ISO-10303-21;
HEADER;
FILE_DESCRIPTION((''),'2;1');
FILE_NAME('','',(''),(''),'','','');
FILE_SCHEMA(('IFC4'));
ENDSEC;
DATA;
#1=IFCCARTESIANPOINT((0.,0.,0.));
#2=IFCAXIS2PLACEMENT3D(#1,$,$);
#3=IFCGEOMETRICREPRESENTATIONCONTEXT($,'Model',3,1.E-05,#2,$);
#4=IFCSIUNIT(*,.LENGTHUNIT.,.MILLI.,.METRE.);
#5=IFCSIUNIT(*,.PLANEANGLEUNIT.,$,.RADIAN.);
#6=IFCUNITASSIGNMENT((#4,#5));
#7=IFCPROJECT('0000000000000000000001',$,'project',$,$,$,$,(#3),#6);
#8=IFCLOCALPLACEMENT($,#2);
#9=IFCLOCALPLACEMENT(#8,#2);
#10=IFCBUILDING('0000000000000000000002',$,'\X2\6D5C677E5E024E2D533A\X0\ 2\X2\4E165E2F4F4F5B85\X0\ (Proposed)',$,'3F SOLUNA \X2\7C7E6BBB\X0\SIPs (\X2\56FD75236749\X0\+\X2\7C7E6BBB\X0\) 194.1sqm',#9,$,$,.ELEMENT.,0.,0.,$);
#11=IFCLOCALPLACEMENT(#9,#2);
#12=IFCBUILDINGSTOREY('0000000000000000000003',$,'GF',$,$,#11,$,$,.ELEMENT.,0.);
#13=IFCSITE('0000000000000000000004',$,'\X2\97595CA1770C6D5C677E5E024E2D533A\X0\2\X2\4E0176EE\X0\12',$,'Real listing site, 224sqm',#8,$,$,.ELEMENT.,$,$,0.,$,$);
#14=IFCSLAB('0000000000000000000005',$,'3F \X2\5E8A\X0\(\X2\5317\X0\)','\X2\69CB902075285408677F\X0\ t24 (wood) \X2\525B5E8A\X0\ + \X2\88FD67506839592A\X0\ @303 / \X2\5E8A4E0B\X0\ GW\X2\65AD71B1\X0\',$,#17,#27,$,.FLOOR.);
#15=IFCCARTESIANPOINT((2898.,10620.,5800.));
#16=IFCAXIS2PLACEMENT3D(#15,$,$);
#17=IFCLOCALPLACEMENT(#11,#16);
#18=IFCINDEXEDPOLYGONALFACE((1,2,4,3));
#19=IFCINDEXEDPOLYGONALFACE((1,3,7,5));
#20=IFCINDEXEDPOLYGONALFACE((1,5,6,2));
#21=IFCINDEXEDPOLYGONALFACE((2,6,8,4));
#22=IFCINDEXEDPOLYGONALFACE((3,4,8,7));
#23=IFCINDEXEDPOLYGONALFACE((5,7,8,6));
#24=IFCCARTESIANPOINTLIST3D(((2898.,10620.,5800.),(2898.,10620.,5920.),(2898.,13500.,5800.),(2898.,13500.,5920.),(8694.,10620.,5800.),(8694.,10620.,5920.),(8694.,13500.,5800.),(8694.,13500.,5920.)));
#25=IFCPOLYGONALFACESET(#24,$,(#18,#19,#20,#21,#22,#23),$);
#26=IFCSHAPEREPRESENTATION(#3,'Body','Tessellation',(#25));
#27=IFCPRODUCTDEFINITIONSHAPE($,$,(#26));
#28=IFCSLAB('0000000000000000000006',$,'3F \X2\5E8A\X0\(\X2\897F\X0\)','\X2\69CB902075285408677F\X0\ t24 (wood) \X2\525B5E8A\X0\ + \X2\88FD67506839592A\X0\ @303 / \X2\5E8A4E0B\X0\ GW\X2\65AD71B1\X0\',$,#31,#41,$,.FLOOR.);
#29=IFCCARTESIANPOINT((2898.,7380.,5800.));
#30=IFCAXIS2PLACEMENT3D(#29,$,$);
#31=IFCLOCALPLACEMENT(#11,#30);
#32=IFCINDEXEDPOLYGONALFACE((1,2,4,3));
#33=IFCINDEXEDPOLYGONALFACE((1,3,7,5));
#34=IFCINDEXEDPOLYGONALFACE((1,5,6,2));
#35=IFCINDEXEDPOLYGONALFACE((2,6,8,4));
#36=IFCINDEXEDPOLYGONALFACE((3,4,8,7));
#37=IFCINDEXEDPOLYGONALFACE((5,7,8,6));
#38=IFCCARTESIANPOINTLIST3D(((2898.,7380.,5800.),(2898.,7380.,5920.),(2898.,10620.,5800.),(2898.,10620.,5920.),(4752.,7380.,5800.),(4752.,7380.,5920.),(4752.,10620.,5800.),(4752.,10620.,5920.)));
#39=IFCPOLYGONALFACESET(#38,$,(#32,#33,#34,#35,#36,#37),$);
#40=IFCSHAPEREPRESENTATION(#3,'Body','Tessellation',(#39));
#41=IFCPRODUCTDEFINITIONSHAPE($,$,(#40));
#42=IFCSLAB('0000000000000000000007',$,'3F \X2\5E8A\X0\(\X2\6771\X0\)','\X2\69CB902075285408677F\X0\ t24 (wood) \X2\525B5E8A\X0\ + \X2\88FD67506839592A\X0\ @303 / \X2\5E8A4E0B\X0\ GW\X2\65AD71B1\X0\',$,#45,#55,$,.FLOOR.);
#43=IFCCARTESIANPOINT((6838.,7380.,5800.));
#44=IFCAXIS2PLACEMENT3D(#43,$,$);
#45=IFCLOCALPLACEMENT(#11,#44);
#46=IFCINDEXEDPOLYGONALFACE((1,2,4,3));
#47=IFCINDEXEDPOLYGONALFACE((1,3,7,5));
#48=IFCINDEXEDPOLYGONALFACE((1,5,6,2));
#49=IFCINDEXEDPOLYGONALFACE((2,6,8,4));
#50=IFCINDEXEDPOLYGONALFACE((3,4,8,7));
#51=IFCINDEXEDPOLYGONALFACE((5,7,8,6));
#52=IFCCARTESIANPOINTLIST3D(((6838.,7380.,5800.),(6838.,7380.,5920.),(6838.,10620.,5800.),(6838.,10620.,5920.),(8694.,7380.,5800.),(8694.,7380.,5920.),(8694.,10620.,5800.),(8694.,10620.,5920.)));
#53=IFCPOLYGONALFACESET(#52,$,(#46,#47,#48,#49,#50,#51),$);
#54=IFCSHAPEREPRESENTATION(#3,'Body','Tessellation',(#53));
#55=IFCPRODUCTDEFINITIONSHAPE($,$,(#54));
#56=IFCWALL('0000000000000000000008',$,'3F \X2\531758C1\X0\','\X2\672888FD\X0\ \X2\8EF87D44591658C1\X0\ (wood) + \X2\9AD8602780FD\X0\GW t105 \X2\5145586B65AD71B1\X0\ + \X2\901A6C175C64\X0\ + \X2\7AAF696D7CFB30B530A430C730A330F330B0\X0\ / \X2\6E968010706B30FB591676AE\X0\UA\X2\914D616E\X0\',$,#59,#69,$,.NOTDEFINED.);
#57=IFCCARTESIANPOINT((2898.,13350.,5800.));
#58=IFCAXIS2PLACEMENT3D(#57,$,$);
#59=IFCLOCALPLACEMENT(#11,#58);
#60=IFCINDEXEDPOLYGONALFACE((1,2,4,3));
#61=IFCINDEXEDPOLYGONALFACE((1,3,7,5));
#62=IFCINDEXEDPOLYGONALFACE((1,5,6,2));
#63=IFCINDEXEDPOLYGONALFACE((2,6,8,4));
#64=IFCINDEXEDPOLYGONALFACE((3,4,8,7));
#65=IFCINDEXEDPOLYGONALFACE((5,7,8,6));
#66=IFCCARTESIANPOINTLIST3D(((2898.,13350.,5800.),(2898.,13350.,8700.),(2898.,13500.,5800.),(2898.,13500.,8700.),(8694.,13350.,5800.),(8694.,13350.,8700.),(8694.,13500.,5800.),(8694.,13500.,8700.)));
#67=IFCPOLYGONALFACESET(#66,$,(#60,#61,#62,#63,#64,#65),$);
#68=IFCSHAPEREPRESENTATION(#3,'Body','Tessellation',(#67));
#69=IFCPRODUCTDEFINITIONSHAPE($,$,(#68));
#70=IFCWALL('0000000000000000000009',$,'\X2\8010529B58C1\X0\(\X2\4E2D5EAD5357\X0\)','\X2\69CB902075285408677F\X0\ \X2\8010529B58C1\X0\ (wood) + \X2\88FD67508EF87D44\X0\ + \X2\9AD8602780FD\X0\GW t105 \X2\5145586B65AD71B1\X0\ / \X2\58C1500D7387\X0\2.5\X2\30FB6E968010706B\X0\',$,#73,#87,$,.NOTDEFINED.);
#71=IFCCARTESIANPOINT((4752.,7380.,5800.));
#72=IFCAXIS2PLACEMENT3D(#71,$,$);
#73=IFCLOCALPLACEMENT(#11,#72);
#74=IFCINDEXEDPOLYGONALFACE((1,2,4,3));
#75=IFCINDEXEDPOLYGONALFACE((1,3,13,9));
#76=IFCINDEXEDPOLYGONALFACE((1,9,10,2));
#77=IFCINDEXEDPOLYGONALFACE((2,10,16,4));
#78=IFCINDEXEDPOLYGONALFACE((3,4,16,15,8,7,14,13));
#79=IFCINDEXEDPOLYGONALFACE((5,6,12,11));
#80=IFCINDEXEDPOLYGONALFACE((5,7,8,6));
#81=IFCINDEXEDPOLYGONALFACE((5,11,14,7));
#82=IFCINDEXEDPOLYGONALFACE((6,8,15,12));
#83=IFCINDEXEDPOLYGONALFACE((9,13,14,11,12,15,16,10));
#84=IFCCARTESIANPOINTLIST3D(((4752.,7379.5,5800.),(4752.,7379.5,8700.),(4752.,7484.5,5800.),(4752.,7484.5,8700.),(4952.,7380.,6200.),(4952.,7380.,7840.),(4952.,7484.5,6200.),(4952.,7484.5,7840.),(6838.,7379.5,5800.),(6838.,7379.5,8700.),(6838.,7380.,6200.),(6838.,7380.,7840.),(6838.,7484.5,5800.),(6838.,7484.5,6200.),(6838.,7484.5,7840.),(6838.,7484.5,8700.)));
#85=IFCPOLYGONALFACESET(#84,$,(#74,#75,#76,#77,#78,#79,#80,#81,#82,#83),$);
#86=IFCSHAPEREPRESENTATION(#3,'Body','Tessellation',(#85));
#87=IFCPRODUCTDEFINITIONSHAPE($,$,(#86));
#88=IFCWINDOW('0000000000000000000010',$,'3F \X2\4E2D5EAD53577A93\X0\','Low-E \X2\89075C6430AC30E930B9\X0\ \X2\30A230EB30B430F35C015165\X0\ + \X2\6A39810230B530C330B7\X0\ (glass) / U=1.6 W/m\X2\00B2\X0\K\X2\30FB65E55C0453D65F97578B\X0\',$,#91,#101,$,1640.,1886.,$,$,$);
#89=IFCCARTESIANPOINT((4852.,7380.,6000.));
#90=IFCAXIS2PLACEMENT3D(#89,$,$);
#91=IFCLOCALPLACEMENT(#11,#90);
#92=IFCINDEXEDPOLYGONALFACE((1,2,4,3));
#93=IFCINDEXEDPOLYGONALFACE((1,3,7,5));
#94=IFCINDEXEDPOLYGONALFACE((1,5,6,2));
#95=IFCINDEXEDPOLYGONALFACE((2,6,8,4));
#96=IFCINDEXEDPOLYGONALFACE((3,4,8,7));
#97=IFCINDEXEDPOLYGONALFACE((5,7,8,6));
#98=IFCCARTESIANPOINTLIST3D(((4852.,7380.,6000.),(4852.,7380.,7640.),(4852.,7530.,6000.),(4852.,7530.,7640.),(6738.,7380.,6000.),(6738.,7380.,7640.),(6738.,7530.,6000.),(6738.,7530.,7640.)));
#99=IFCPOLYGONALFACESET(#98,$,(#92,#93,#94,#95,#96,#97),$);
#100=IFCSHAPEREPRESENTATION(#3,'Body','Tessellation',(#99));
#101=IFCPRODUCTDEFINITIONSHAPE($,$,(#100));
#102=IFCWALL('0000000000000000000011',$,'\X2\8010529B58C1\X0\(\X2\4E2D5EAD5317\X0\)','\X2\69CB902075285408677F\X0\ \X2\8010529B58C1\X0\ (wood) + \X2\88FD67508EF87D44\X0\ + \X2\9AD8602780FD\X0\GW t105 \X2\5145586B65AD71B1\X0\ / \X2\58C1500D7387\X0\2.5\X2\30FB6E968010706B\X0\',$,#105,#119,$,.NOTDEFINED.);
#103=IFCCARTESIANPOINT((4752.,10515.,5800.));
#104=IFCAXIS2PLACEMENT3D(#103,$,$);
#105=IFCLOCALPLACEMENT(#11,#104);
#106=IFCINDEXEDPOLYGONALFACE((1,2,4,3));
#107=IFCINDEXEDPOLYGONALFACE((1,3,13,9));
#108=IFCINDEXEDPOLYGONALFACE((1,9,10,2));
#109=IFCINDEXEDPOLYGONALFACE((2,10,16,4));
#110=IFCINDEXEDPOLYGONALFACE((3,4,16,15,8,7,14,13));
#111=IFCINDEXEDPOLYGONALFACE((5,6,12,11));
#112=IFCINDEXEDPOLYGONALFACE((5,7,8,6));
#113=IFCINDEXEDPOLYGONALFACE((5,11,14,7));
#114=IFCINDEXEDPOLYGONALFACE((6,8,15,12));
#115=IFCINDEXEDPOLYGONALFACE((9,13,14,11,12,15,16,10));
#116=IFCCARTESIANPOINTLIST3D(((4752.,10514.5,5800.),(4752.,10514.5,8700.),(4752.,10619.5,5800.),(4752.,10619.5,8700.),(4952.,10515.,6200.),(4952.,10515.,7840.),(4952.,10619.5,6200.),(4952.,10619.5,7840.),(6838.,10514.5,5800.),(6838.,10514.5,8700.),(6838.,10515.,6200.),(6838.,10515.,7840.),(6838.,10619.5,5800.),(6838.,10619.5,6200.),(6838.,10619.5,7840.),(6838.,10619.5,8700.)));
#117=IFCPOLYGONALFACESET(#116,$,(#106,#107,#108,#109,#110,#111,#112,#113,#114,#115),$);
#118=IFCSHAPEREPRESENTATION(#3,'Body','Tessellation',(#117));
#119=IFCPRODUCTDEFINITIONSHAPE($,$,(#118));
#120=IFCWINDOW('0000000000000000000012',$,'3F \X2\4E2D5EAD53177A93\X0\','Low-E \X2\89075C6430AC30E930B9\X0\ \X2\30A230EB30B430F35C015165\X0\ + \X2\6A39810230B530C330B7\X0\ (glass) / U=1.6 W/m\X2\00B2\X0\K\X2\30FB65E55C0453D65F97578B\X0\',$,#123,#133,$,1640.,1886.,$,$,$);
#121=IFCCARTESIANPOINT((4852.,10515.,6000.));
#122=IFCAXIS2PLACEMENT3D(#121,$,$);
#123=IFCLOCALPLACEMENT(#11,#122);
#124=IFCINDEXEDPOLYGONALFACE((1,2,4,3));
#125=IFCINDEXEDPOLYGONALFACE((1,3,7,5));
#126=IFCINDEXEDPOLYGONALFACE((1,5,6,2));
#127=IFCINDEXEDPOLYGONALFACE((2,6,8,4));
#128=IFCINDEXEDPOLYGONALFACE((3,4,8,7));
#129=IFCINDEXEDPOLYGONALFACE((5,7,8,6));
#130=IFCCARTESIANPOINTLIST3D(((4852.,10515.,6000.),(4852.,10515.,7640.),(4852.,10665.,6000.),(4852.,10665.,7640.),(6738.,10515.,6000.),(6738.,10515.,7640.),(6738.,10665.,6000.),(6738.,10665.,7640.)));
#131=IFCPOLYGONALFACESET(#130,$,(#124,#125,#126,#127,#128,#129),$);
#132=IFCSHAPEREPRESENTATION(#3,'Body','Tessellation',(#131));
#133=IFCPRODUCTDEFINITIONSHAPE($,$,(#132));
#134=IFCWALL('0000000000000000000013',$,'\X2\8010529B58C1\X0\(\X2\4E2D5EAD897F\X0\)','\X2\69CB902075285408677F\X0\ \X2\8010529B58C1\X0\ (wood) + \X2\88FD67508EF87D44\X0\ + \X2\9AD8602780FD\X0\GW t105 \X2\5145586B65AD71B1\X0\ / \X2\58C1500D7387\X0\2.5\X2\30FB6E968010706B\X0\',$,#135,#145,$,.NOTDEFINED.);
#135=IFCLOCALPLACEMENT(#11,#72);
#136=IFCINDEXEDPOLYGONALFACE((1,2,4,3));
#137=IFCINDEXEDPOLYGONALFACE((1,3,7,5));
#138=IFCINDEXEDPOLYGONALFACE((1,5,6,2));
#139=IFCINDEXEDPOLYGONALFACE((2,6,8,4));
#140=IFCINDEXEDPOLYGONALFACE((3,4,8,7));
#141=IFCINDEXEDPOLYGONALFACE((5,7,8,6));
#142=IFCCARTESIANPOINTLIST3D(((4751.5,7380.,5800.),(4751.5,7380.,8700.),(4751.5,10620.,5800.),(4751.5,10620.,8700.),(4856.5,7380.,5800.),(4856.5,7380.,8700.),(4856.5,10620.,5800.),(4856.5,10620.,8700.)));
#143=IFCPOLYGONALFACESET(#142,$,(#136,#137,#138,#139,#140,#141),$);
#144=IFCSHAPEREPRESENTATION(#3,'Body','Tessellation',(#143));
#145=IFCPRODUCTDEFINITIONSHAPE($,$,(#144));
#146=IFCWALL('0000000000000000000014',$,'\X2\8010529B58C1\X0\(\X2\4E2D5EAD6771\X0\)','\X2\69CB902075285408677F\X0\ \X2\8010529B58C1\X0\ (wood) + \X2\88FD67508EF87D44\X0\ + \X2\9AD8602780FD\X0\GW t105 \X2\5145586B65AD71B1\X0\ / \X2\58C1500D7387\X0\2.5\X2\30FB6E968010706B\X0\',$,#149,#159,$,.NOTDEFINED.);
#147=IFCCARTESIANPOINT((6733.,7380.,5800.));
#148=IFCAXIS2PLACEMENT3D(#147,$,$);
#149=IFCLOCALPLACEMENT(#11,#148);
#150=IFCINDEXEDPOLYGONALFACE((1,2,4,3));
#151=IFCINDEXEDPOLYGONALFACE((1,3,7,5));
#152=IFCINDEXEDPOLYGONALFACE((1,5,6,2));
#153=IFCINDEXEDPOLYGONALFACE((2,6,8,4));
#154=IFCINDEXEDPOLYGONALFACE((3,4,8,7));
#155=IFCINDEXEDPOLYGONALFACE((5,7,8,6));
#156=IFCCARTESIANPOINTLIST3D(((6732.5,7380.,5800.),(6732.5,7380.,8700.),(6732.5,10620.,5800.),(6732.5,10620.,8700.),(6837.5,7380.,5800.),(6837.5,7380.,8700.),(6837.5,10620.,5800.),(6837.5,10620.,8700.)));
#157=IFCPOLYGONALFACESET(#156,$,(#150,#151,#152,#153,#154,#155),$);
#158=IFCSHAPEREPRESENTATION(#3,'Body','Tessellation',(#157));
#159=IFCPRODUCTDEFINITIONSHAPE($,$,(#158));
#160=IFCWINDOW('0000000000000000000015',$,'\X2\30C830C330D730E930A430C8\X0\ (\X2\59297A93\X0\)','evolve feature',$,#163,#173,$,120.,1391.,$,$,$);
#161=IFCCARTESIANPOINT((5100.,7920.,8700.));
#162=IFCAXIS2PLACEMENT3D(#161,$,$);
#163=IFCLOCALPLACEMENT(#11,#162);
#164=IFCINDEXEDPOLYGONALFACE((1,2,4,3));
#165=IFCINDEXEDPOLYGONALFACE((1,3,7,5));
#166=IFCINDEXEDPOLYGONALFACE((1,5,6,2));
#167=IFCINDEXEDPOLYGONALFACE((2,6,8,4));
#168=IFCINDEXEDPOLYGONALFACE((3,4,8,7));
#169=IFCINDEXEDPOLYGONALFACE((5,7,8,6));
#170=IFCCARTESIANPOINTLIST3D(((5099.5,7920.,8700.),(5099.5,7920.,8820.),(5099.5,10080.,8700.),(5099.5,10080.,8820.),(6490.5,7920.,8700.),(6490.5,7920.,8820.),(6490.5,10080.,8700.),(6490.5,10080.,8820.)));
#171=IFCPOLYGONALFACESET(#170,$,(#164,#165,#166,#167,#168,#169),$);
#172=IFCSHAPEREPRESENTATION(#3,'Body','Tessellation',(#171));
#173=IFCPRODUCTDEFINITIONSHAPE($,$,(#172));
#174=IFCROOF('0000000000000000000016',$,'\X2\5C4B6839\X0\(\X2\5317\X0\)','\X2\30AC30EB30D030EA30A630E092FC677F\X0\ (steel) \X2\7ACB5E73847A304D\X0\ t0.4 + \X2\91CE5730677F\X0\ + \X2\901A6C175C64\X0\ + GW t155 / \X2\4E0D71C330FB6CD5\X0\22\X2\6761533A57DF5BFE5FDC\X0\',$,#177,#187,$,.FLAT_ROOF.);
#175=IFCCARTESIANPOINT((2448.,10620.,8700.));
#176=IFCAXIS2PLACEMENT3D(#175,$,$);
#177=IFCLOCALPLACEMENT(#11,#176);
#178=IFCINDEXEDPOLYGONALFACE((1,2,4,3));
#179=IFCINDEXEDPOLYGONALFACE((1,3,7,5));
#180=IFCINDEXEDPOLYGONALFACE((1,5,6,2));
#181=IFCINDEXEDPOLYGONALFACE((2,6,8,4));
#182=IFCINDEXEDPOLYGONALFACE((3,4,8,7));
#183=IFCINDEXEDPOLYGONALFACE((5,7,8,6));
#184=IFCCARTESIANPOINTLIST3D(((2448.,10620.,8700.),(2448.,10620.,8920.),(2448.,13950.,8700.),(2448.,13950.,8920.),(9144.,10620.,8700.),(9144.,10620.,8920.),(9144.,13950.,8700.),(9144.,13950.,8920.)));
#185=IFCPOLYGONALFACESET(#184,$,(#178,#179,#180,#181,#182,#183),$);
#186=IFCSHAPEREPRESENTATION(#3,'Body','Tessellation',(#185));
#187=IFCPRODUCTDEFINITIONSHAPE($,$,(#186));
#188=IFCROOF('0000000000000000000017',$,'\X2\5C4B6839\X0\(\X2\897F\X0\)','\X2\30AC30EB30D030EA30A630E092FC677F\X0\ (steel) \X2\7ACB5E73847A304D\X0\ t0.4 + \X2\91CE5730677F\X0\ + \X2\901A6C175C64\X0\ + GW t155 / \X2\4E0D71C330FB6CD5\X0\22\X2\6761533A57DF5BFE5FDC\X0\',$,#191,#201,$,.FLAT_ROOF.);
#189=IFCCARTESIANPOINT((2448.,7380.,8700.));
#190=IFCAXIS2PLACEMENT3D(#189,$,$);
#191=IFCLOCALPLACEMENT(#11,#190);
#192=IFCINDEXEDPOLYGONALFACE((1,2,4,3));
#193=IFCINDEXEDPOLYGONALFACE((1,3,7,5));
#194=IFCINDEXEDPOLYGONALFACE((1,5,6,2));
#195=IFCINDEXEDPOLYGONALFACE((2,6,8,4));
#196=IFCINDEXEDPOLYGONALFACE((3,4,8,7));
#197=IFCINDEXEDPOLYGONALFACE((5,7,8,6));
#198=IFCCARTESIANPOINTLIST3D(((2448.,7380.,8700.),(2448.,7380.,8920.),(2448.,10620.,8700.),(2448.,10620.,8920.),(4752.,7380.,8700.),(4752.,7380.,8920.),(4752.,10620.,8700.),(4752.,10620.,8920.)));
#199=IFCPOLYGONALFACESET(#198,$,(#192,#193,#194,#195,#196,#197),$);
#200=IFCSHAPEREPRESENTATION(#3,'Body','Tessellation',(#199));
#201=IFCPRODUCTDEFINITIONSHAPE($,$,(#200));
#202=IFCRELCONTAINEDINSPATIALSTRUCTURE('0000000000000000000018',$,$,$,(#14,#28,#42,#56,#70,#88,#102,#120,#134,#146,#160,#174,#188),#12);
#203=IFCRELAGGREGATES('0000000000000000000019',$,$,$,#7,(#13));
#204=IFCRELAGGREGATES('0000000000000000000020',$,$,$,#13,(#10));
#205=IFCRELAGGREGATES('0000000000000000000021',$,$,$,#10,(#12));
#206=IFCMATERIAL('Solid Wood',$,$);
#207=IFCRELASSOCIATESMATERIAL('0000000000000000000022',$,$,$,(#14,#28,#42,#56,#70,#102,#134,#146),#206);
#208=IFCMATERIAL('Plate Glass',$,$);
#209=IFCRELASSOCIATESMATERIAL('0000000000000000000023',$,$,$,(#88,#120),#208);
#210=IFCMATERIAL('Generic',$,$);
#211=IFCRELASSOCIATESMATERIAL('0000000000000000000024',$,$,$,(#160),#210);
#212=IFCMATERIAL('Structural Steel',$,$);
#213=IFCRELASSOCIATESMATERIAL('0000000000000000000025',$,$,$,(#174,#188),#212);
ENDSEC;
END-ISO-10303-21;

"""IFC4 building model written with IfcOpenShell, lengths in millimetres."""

from ifc_helpers import new_model, si_unit, frame, frame_2d, origin, place, context, project, spatial, rectangle, extrude, material, element, fill, save


model = new_model("IFC4")

# Units and contexts
model_context = context("Model", 3, precision=1e-05, world=origin())
ifc_project = project(units=[si_unit("LENGTHUNIT", "METRE", prefix="MILLI"), si_unit("PLANEANGLEUNIT", "RADIAN")], contexts=[model_context])

# Site, building, storey
site_placement = place(None, origin())
site = spatial("IfcSite", under=ifc_project, at=site_placement, Name="静岡県浜松市中区2丁目12", ObjectType="Real listing site, 224sqm", CompositionType="ELEMENT", RefElevation=0.0)
building_placement = place(site_placement, origin())
building = spatial("IfcBuilding", under=site, at=building_placement, Name="浜松市中区 2世帯住宅 (Proposed)", ObjectType="3F SOLUNA 籾殻SIPs (国産杉+籾殻) 194.1sqm", CompositionType="ELEMENT", ElevationOfRefHeight=0.0, ElevationOfTerrain=0.0)
storey_placement = place(building_placement, origin())
storey = spatial("IfcBuildingStorey", under=building, at=storey_placement, Name="GF", CompositionType="ELEMENT", Elevation=0.0)

# Slabs
ifc_material_1 = material(Name="Solid Wood")
slab_1_placement = place(storey_placement, frame((2898.0, 10620.0, 5800.0)))
element("IfcSlab", 1, at=slab_1_placement, inside=storey, material=ifc_material_1, Name="3F 床(北)", Description="構造用合板 t24 (wood) 剛床 + 製材根太 @303 / 床下 GW断熱", PredefinedType="FLOOR", context=model_context, shape_type="SweptSolid", body=[
    extrude(rectangle(XDim=5796.0, YDim=2880.0, at=frame_2d((2898.0, 1440.0))), frame((2898.0, 10620.0, 5800.0)), (0.0, 0.0, 1.0), 120.0),
])
slab_2_placement = place(storey_placement, frame((2898.0, 7380.0, 5800.0)))
element("IfcSlab", 2, at=slab_2_placement, inside=storey, material=ifc_material_1, Name="3F 床(西)", Description="構造用合板 t24 (wood) 剛床 + 製材根太 @303 / 床下 GW断熱", PredefinedType="FLOOR", context=model_context, shape_type="SweptSolid", body=[
    extrude(rectangle(XDim=1854.0, YDim=3240.0, at=frame_2d((927.0, 1620.0))), frame((2898.0, 7380.0, 5800.0)), (0.0, 0.0, 1.0), 120.0),
])
slab_3_placement = place(storey_placement, frame((6838.0, 7380.0, 5800.0)))
element("IfcSlab", 3, at=slab_3_placement, inside=storey, material=ifc_material_1, Name="3F 床(東)", Description="構造用合板 t24 (wood) 剛床 + 製材根太 @303 / 床下 GW断熱", PredefinedType="FLOOR", context=model_context, shape_type="SweptSolid", body=[
    extrude(rectangle(XDim=1856.0, YDim=3240.0, at=frame_2d((928.0, 1620.0))), frame((6838.0, 7380.0, 5800.0)), (0.0, 0.0, 1.0), 120.0),
])

# Wall
wall_1_placement = place(storey_placement, frame((2898.0, 13350.0, 5800.0)))
element("IfcWall", 4, at=wall_1_placement, inside=storey, material=ifc_material_1, Name="3F 北壁", Description="木製 軸組外壁 (wood) + 高性能GW t105 充填断熱 + 通気層 + 窯業系サイディング / 準耐火・外皮UA配慮", PredefinedType="NOTDEFINED", context=model_context, shape_type="SweptSolid", body=[
    extrude(rectangle(XDim=5796.0, YDim=150.0, at=frame_2d((2898.0, 75.0))), frame((2898.0, 13350.0, 5800.0)), (0.0, 0.0, 1.0), 2900.0),
])

# Walls, openings, windows
wall_2_placement = place(storey_placement, frame((4752.0, 7380.0, 5800.0)))
wall_2 = element("IfcWall", 5, at=wall_2_placement, inside=storey, material=ifc_material_1, Name="耐力壁(中庭南)", Description="構造用合板 耐力壁 (wood) + 製材軸組 + 高性能GW t105 充填断熱 / 壁倍率2.5・準耐火", PredefinedType="NOTDEFINED", context=model_context, shape_type="SweptSolid", body=[
    extrude(rectangle(XDim=2086.0, YDim=105.0, at=frame_2d((1043.0, 52.0))), frame((4752.0, 7380.0, 5800.0)), (0.0, 0.0, 1.0), 2900.0),
])
opening_1_placement = place(storey_placement, frame((4852.0, 7380.0, 6000.0)))
opening_1 = element("IfcOpeningElement", 6, at=opening_1_placement, cuts=wall_2, PredefinedType="NOTDEFINED", context=model_context, shape_type="SweptSolid", body=[
    extrude(rectangle(XDim=1886.0, YDim=150.0, at=frame_2d((943.0, 75.0))), frame((4852.0, 7380.0, 6000.0)), (0.0, 0.0, 1.0), 1640.0),
])
ifc_material_2 = material(Name="Plate Glass")
window_1_placement = place(storey_placement, frame((4852.0, 7380.0, 6000.0)))
window_1 = element("IfcWindow", 7, at=window_1_placement, inside=storey, material=ifc_material_2, Name="3F 中庭南窓", Description="Low-E 複層ガラス アルゴン封入 + 樹脂サッシ (glass) / U=1.6 W/m²K・日射取得型", OverallHeight=1640.0, OverallWidth=1886.0, context=model_context, shape_type="SweptSolid", body=[
    extrude(rectangle(XDim=1886.0, YDim=150.0, at=frame_2d((943.0, 75.0))), frame((4852.0, 7380.0, 6000.0)), (0.0, 0.0, 1.0), 1640.0),
])
fill(opening_1, window_1)
wall_3_placement = place(storey_placement, frame((4752.0, 10515.0, 5800.0)))
wall_3 = element("IfcWall", 8, at=wall_3_placement, inside=storey, material=ifc_material_1, Name="耐力壁(中庭北)", Description="構造用合板 耐力壁 (wood) + 製材軸組 + 高性能GW t105 充填断熱 / 壁倍率2.5・準耐火", PredefinedType="NOTDEFINED", context=model_context, shape_type="SweptSolid", body=[
    extrude(rectangle(XDim=2086.0, YDim=105.0, at=frame_2d((1043.0, 52.0))), frame((4752.0, 10515.0, 5800.0)), (0.0, 0.0, 1.0), 2900.0),
])
opening_2_placement = place(storey_placement, frame((4852.0, 10515.0, 6000.0)))
opening_2 = element("IfcOpeningElement", 9, at=opening_2_placement, cuts=wall_3, PredefinedType="NOTDEFINED", context=model_context, shape_type="SweptSolid", body=[
    extrude(rectangle(XDim=1886.0, YDim=150.0, at=frame_2d((943.0, 75.0))), frame((4852.0, 10515.0, 6000.0)), (0.0, 0.0, 1.0), 1640.0),
])
window_2_placement = place(storey_placement, frame((4852.0, 10515.0, 6000.0)))
window_2 = element("IfcWindow", 10, at=window_2_placement, inside=storey, material=ifc_material_2, Name="3F 中庭北窓", Description="Low-E 複層ガラス アルゴン封入 + 樹脂サッシ (glass) / U=1.6 W/m²K・日射取得型", OverallHeight=1640.0, OverallWidth=1886.0, context=model_context, shape_type="SweptSolid", body=[
    extrude(rectangle(XDim=1886.0, YDim=150.0, at=frame_2d((943.0, 75.0))), frame((4852.0, 10515.0, 6000.0)), (0.0, 0.0, 1.0), 1640.0),
])
fill(opening_2, window_2)

# Walls
wall_4_placement = place(storey_placement, frame((4752.0, 7380.0, 5800.0)))
element("IfcWall", 11, at=wall_4_placement, inside=storey, material=ifc_material_1, Name="耐力壁(中庭西)", Description="構造用合板 耐力壁 (wood) + 製材軸組 + 高性能GW t105 充填断熱 / 壁倍率2.5・準耐火", PredefinedType="NOTDEFINED", context=model_context, shape_type="SweptSolid", body=[
    extrude(rectangle(XDim=105.0, YDim=3240.0, at=frame_2d((52.0, 1620.0))), frame((4752.0, 7380.0, 5800.0)), (0.0, 0.0, 1.0), 2900.0),
])
wall_5_placement = place(storey_placement, frame((6733.0, 7380.0, 5800.0)))
element("IfcWall", 12, at=wall_5_placement, inside=storey, material=ifc_material_1, Name="耐力壁(中庭東)", Description="構造用合板 耐力壁 (wood) + 製材軸組 + 高性能GW t105 充填断熱 / 壁倍率2.5・準耐火", PredefinedType="NOTDEFINED", context=model_context, shape_type="SweptSolid", body=[
    extrude(rectangle(XDim=105.0, YDim=3240.0, at=frame_2d((52.0, 1620.0))), frame((6733.0, 7380.0, 5800.0)), (0.0, 0.0, 1.0), 2900.0),
])

# Window
ifc_material_3 = material(Name="Generic")
window_3_placement = place(storey_placement, frame((5100.0, 7920.0, 8700.0)))
element("IfcWindow", 13, at=window_3_placement, inside=storey, material=ifc_material_3, Name="トップライト (天窓)", Description="evolve feature", OverallHeight=120.0, OverallWidth=1391.0, context=model_context, shape_type="SweptSolid", body=[
    extrude(rectangle(XDim=1391.0, YDim=2160.0, at=frame_2d((695.0, 1080.0))), frame((5100.0, 7920.0, 8700.0)), (0.0, 0.0, 1.0), 120.0),
])

# Roofs
ifc_material_4 = material(Name="Structural Steel")
for number, where, name in (
    (14, (2448.0, 10620.0, 8700.0), "屋根(北)"),
):
    element("IfcRoof", number, at=place(storey_placement, frame(where)), inside=storey, material=ifc_material_4, Name=name, Description="ガルバリウム鋼板 (steel) 立平葺き t0.4 + 野地板 + 通気層 + GW t155 / 不燃・法22条区域対応", PredefinedType="FLAT_ROOF", context=model_context, shape_type="SweptSolid", body=[
        extrude(rectangle(XDim=6696.0, YDim=3330.0, at=frame_2d((3348.0, 1665.0))), frame((2448.0, 10620.0, 8700.0)), (0.0, 0.0, 1.0), 220.0),
    ])
roof_1_placement = place(storey_placement, frame((2448.0, 7380.0, 8700.0)))
element("IfcRoof", 15, at=roof_1_placement, inside=storey, material=ifc_material_4, Name="屋根(西)", Description="ガルバリウム鋼板 (steel) 立平葺き t0.4 + 野地板 + 通気層 + GW t155 / 不燃・法22条区域対応", PredefinedType="FLAT_ROOF", context=model_context, shape_type="SweptSolid", body=[
    extrude(rectangle(XDim=2304.0, YDim=3240.0, at=frame_2d((1152.0, 1620.0))), frame((2448.0, 7380.0, 8700.0)), (0.0, 0.0, 1.0), 220.0),
])

save(model, "model.ifc")
